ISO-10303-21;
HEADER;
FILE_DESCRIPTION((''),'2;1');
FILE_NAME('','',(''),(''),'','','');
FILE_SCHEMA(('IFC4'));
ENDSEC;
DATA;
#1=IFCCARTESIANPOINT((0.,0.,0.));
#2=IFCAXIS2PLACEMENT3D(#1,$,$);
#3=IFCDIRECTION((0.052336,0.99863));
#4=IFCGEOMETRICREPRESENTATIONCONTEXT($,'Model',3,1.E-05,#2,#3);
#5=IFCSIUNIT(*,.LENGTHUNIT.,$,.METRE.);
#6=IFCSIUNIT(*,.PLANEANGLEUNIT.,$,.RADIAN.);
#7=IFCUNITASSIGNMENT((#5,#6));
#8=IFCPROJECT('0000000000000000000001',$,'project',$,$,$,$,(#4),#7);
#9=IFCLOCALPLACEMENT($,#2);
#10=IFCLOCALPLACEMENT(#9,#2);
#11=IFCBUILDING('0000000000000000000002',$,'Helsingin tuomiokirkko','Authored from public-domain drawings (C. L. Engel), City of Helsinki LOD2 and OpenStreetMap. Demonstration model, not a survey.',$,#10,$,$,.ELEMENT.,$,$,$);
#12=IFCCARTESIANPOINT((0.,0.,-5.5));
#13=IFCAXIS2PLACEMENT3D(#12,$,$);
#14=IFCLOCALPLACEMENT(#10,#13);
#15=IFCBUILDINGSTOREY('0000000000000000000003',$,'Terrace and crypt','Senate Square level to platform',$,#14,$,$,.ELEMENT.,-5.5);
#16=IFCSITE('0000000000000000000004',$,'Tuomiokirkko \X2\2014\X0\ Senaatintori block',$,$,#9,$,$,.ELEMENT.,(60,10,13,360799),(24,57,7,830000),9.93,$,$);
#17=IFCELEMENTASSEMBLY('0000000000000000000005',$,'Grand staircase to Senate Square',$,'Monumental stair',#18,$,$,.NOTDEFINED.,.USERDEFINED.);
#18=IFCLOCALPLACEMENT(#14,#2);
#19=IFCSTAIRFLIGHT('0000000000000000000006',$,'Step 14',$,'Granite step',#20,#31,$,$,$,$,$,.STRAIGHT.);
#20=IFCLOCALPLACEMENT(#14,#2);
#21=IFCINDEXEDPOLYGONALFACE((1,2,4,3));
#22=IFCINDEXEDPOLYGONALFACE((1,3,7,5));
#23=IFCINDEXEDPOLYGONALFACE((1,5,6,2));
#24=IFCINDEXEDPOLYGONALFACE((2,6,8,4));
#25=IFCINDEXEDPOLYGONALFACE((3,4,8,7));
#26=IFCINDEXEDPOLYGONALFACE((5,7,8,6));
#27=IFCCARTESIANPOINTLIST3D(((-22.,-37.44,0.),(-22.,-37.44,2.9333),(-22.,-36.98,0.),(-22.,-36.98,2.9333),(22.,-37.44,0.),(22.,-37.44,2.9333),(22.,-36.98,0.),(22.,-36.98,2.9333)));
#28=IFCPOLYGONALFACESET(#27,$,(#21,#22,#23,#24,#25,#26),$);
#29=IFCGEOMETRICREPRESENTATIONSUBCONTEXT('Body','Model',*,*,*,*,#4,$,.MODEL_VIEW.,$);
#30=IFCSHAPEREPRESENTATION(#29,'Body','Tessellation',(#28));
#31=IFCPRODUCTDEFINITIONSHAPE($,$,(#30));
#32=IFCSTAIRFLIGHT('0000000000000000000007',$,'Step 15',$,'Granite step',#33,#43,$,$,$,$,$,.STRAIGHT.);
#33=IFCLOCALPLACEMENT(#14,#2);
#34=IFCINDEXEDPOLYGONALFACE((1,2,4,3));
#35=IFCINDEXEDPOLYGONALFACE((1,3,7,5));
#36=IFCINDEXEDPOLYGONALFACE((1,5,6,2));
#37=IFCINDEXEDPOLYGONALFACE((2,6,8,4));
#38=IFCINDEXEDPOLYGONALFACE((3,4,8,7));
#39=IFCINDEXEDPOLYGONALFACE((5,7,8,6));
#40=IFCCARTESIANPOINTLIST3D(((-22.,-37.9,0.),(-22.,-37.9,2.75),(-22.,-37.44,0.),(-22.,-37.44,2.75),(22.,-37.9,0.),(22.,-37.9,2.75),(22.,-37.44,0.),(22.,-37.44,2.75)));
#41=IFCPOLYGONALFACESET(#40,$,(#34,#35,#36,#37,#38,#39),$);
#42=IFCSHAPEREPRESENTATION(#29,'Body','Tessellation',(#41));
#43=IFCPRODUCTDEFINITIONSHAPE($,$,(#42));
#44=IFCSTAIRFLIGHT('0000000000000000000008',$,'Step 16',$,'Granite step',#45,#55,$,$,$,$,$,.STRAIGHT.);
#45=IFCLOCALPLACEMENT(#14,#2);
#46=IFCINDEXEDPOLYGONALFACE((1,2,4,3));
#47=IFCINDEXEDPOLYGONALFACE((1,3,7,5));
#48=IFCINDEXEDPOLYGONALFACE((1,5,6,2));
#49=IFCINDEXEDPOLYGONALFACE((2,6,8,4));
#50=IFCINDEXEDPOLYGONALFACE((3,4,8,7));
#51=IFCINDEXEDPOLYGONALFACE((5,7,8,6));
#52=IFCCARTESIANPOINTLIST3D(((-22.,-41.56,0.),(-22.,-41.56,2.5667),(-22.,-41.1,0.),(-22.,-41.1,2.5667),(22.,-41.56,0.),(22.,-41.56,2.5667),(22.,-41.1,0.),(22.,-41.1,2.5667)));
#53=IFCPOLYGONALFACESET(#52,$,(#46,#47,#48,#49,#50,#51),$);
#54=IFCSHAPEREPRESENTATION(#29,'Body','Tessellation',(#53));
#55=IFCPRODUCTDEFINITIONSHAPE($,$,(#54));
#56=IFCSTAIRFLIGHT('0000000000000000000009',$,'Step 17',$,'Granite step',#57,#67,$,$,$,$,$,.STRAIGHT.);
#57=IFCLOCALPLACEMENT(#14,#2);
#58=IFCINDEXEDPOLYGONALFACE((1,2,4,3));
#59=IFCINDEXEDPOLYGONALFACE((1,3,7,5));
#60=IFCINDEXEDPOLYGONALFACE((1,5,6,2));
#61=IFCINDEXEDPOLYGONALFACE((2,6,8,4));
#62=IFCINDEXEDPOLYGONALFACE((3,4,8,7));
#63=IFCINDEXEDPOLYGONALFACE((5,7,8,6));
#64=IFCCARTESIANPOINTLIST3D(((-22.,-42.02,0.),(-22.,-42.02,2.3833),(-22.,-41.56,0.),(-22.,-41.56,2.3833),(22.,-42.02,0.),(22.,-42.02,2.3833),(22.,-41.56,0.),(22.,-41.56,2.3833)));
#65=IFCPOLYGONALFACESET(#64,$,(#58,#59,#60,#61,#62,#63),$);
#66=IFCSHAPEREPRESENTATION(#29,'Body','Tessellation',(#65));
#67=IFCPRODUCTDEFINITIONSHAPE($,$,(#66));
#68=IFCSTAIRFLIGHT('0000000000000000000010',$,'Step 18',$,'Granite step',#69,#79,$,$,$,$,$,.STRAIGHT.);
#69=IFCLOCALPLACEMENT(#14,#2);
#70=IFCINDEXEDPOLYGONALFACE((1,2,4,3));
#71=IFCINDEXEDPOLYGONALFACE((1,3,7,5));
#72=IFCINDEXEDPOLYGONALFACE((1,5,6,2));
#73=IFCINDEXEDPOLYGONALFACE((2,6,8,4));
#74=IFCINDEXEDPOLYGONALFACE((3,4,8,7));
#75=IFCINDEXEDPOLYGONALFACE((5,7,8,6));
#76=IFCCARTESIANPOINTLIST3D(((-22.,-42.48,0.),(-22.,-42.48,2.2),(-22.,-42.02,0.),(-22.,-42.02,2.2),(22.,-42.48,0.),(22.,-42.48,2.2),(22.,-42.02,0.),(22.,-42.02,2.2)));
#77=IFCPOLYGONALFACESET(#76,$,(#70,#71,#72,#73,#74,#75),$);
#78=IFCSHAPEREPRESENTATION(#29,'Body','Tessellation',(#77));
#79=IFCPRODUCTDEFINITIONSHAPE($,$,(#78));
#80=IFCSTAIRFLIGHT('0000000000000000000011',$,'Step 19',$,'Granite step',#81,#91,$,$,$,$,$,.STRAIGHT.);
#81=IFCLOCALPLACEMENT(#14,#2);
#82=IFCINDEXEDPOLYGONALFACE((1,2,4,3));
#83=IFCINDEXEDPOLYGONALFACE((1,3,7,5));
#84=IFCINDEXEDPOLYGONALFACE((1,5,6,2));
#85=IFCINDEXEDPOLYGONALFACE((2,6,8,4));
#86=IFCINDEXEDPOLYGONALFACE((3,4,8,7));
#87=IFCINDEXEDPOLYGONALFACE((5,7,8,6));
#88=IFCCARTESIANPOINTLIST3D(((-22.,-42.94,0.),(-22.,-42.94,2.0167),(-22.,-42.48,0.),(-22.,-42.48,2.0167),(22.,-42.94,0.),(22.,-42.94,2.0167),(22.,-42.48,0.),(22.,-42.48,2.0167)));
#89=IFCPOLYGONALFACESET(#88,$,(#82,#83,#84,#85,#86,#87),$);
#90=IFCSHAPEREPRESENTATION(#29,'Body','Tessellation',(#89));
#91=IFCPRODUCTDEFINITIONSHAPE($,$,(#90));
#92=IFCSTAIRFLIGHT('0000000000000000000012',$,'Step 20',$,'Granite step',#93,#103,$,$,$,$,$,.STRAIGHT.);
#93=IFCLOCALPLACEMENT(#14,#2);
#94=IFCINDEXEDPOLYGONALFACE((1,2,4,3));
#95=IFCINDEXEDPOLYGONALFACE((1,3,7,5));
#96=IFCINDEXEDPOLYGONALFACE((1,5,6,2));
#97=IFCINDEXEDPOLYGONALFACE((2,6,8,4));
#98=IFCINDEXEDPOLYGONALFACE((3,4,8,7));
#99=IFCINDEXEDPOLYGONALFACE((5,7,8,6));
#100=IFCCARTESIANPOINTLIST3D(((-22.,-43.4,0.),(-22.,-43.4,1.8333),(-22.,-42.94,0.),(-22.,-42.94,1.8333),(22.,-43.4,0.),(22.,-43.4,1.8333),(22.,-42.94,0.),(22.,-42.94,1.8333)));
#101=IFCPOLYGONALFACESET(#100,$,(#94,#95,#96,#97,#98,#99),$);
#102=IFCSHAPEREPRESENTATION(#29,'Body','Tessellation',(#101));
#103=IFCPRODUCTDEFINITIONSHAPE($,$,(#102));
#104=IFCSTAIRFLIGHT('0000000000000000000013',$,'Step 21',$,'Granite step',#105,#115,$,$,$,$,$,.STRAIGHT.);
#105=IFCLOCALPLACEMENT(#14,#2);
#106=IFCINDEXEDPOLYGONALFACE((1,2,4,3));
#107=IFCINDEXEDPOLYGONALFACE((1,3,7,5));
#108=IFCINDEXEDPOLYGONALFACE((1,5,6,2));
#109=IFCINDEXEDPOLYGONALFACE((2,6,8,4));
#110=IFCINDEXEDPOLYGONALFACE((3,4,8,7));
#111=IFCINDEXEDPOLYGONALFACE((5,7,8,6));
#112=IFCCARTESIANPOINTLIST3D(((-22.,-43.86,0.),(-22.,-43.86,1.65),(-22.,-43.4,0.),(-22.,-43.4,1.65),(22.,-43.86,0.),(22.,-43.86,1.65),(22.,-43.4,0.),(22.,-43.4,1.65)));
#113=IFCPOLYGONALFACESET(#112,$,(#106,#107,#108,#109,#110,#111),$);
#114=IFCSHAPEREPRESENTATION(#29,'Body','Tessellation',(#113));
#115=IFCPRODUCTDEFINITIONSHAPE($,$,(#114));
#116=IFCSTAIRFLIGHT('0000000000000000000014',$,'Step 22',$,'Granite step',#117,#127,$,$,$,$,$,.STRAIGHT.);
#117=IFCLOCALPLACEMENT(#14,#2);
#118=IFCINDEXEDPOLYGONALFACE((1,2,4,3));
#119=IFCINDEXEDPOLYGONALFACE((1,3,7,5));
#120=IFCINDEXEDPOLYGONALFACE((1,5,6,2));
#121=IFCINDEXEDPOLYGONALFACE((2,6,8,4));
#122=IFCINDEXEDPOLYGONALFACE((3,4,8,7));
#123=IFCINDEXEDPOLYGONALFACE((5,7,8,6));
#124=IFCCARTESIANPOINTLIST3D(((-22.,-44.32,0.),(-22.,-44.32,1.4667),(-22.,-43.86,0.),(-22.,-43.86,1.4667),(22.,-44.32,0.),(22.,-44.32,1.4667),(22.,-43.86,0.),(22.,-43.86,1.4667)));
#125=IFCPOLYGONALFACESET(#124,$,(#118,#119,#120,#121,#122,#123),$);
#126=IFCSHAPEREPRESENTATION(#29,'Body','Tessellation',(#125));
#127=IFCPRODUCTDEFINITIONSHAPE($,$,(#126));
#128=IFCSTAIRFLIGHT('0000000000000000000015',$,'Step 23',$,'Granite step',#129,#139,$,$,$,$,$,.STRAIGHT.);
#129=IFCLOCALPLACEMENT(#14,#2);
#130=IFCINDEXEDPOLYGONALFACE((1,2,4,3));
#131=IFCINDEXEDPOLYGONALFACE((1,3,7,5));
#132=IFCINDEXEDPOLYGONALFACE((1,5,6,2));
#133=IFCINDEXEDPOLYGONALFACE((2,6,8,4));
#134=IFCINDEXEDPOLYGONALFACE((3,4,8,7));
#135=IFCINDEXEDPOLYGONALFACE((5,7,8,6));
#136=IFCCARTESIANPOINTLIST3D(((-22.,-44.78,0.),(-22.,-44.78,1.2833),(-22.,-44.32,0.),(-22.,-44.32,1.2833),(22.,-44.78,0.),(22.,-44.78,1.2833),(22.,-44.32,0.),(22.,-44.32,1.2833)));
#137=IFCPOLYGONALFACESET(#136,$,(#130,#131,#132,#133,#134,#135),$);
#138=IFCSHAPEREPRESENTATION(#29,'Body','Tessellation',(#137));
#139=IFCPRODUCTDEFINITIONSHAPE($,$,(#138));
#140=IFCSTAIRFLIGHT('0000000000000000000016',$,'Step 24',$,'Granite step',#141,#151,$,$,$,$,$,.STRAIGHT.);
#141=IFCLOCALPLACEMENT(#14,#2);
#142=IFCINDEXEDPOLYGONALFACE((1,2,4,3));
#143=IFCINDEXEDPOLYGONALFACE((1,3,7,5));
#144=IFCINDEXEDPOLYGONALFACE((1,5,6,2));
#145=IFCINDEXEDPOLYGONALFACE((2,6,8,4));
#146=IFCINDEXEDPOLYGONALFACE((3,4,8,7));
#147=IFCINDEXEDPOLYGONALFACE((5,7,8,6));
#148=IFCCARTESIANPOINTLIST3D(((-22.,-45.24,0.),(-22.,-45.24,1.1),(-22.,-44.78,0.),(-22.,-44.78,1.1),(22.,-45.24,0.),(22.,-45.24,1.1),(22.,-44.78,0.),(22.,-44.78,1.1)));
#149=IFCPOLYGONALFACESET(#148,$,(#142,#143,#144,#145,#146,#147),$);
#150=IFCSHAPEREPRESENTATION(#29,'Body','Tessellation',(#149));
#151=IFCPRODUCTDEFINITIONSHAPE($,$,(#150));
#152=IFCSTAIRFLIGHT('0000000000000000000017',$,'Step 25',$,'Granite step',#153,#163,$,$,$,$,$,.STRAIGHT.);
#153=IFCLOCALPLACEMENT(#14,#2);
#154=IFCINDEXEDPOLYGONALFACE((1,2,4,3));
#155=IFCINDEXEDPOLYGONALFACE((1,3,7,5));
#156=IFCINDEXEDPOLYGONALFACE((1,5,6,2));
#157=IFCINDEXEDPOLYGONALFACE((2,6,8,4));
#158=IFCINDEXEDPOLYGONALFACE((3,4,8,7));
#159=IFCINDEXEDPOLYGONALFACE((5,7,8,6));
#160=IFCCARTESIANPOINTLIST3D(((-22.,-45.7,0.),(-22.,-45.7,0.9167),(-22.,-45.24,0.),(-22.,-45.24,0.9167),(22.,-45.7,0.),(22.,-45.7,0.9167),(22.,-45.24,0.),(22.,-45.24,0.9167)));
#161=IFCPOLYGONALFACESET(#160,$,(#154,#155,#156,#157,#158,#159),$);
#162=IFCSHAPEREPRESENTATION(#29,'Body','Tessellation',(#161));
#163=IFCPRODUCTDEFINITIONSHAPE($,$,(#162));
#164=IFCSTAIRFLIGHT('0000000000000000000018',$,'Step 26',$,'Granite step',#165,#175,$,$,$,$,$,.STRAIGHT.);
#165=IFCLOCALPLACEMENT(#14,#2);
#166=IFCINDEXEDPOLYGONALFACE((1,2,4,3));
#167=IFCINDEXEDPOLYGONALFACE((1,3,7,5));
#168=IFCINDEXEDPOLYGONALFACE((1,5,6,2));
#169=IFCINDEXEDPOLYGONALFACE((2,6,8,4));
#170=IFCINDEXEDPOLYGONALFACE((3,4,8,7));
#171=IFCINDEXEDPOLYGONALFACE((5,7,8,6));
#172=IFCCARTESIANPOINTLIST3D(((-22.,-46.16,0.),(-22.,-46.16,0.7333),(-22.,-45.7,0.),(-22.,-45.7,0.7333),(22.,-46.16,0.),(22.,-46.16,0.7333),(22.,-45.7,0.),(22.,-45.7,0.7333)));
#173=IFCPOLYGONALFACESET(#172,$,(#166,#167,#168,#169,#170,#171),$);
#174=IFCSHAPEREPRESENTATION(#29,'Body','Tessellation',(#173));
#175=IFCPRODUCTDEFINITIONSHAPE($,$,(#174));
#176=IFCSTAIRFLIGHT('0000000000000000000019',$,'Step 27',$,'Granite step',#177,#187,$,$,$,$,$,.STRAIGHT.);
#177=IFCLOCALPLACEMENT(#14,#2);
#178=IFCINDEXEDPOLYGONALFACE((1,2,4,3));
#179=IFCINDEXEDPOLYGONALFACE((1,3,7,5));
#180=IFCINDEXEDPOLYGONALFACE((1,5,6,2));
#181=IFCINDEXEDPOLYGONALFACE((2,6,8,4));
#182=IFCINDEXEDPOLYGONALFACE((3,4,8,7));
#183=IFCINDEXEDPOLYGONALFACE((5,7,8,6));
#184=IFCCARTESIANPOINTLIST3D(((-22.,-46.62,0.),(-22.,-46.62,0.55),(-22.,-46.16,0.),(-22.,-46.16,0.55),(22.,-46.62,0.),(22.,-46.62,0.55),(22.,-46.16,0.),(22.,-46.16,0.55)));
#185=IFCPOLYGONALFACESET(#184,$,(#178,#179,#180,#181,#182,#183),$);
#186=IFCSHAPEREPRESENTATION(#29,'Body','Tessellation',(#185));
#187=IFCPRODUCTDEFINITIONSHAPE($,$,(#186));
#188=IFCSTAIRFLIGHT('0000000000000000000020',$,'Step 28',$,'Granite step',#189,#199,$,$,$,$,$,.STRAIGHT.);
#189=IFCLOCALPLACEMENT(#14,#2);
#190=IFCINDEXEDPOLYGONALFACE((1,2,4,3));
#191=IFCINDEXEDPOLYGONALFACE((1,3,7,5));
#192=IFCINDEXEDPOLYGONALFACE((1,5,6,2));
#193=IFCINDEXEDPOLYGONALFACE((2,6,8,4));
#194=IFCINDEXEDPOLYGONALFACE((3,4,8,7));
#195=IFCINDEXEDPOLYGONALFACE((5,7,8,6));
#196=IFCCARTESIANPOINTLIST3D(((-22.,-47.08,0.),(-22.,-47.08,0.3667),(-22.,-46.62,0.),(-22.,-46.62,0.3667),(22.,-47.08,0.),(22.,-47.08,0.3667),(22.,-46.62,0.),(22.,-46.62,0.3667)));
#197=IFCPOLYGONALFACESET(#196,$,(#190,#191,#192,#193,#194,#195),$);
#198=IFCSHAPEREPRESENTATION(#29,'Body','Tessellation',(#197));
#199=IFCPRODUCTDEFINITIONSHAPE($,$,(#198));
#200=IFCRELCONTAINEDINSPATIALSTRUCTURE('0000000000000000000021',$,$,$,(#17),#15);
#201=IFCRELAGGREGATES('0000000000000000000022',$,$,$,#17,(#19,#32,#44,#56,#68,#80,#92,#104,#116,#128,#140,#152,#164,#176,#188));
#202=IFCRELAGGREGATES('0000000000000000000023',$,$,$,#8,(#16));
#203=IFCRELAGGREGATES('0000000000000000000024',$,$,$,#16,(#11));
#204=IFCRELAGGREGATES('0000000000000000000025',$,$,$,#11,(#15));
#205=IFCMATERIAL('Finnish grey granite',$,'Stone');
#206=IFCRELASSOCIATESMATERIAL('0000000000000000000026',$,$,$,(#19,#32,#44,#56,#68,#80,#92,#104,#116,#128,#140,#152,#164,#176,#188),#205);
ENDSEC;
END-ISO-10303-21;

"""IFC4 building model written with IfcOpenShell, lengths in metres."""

from ifc_helpers import new_model, si_unit, direction, frame, origin, origin_2d_with_axis, place, context, subcontext, project, spatial, rectangle, extrude, material, element, aggregate, save


model = new_model("IFC4")

# Units and contexts
model_context = context("Model", 3, precision=1e-05, world=origin(), true_north=direction((0.052336, 0.99863)))
body_context = subcontext(model_context, "Body", "Model", "MODEL_VIEW")
ifc_project = project(units=[si_unit("LENGTHUNIT", "METRE"), si_unit("PLANEANGLEUNIT", "RADIAN")], contexts=[model_context])

# Site, building, storey
site_placement = place(None, origin())
site = spatial("IfcSite", under=ifc_project, at=site_placement, Name="Tuomiokirkko — Senaatintori block", CompositionType="ELEMENT", RefLatitude=(60, 10, 13, 360799), RefLongitude=(24, 57, 7, 830000), RefElevation=9.93)
building_placement = place(site_placement, origin())
building = spatial("IfcBuilding", under=site, at=building_placement, Name="Helsingin tuomiokirkko", Description="Authored from public-domain drawings (C. L. Engel), City of Helsinki LOD2 and OpenStreetMap. Demonstration model, not a survey.", CompositionType="ELEMENT")
storey_placement = place(building_placement, frame((0.0, 0.0, -5.5)))
storey = spatial("IfcBuildingStorey", under=building, at=storey_placement, Name="Terrace and crypt", Description="Senate Square level to platform", CompositionType="ELEMENT", Elevation=-5.5)

# Element assembly, stair flights
assembly_placement = place(building_placement, origin())
assembly = element("IfcElementAssembly", 1, at=assembly_placement, inside=storey, Name="Grand staircase to Senate Square", ObjectType="Monumental stair", AssemblyPlace="NOTDEFINED", PredefinedType="USERDEFINED")
ifc_material_1 = material(Name="Finnish grey granite", Category="Stone")
stair_flight_1_placement = place(building_placement, origin())
stair_flight_1 = element("IfcStairFlight", 2, at=stair_flight_1_placement, material=ifc_material_1, Name="Step 14", ObjectType="Granite step", PredefinedType="STRAIGHT", context=body_context, shape_type="SweptSolid", body=[
    extrude(rectangle(XDim=44.0, YDim=0.46, at=origin_2d_with_axis()), frame((0.0, -37.21, -5.5)), (0.0, 0.0, 1.0), 2.9333),
])
stair_flight_2_placement = place(building_placement, origin())
stair_flight_2 = element("IfcStairFlight", 3, at=stair_flight_2_placement, material=ifc_material_1, Name="Step 15", ObjectType="Granite step", PredefinedType="STRAIGHT", context=body_context, shape_type="SweptSolid", body=[
    extrude(rectangle(XDim=44.0, YDim=0.46, at=origin_2d_with_axis()), frame((0.0, -37.67, -5.5)), (0.0, 0.0, 1.0), 2.75),
])
stair_flight_3_placement = place(building_placement, origin())
stair_flight_3 = element("IfcStairFlight", 4, at=stair_flight_3_placement, material=ifc_material_1, Name="Step 16", ObjectType="Granite step", PredefinedType="STRAIGHT", context=body_context, shape_type="SweptSolid", body=[
    extrude(rectangle(XDim=44.0, YDim=0.46, at=origin_2d_with_axis()), frame((0.0, -41.33, -5.5)), (0.0, 0.0, 1.0), 2.5667),
])
stair_flight_4_placement = place(building_placement, origin())
stair_flight_4 = element("IfcStairFlight", 5, at=stair_flight_4_placement, material=ifc_material_1, Name="Step 17", ObjectType="Granite step", PredefinedType="STRAIGHT", context=body_context, shape_type="SweptSolid", body=[
    extrude(rectangle(XDim=44.0, YDim=0.46, at=origin_2d_with_axis()), frame((0.0, -41.79, -5.5)), (0.0, 0.0, 1.0), 2.3833),
])
stair_flight_5_placement = place(building_placement, origin())
stair_flight_5 = element("IfcStairFlight", 6, at=stair_flight_5_placement, material=ifc_material_1, Name="Step 18", ObjectType="Granite step", PredefinedType="STRAIGHT", context=body_context, shape_type="SweptSolid", body=[
    extrude(rectangle(XDim=44.0, YDim=0.46, at=origin_2d_with_axis()), frame((0.0, -42.25, -5.5)), (0.0, 0.0, 1.0), 2.2),
])
stair_flight_6_placement = place(building_placement, origin())
stair_flight_6 = element("IfcStairFlight", 7, at=stair_flight_6_placement, material=ifc_material_1, Name="Step 19", ObjectType="Granite step", PredefinedType="STRAIGHT", context=body_context, shape_type="SweptSolid", body=[
    extrude(rectangle(XDim=44.0, YDim=0.46, at=origin_2d_with_axis()), frame((0.0, -42.71, -5.5)), (0.0, 0.0, 1.0), 2.0167),
])
stair_flight_7_placement = place(building_placement, origin())
stair_flight_7 = element("IfcStairFlight", 8, at=stair_flight_7_placement, material=ifc_material_1, Name="Step 20", ObjectType="Granite step", PredefinedType="STRAIGHT", context=body_context, shape_type="SweptSolid", body=[
    extrude(rectangle(XDim=44.0, YDim=0.46, at=origin_2d_with_axis()), frame((0.0, -43.17, -5.5)), (0.0, 0.0, 1.0), 1.8333),
])
stair_flight_8_placement = place(building_placement, origin())
stair_flight_8 = element("IfcStairFlight", 9, at=stair_flight_8_placement, material=ifc_material_1, Name="Step 21", ObjectType="Granite step", PredefinedType="STRAIGHT", context=body_context, shape_type="SweptSolid", body=[
    extrude(rectangle(XDim=44.0, YDim=0.46, at=origin_2d_with_axis()), frame((0.0, -43.63, -5.5)), (0.0, 0.0, 1.0), 1.65),
])
stair_flight_9_placement = place(building_placement, origin())
stair_flight_9 = element("IfcStairFlight", 10, at=stair_flight_9_placement, material=ifc_material_1, Name="Step 22", ObjectType="Granite step", PredefinedType="STRAIGHT", context=body_context, shape_type="SweptSolid", body=[
    extrude(rectangle(XDim=44.0, YDim=0.46, at=origin_2d_with_axis()), frame((0.0, -44.09, -5.5)), (0.0, 0.0, 1.0), 1.4667),
])
stair_flight_10_placement = place(building_placement, origin())
stair_flight_10 = element("IfcStairFlight", 11, at=stair_flight_10_placement, material=ifc_material_1, Name="Step 23", ObjectType="Granite step", PredefinedType="STRAIGHT", context=body_context, shape_type="SweptSolid", body=[
    extrude(rectangle(XDim=44.0, YDim=0.46, at=origin_2d_with_axis()), frame((0.0, -44.55, -5.5)), (0.0, 0.0, 1.0), 1.2833),
])
stair_flight_11_placement = place(building_placement, origin())
stair_flight_11 = element("IfcStairFlight", 12, at=stair_flight_11_placement, material=ifc_material_1, Name="Step 24", ObjectType="Granite step", PredefinedType="STRAIGHT", context=body_context, shape_type="SweptSolid", body=[
    extrude(rectangle(XDim=44.0, YDim=0.46, at=origin_2d_with_axis()), frame((0.0, -45.01, -5.5)), (0.0, 0.0, 1.0), 1.1),
])
stair_flight_12_placement = place(building_placement, origin())
stair_flight_12 = element("IfcStairFlight", 13, at=stair_flight_12_placement, material=ifc_material_1, Name="Step 25", ObjectType="Granite step", PredefinedType="STRAIGHT", context=body_context, shape_type="SweptSolid", body=[
    extrude(rectangle(XDim=44.0, YDim=0.46, at=origin_2d_with_axis()), frame((0.0, -45.47, -5.5)), (0.0, 0.0, 1.0), 0.9167),
])
stair_flight_13_placement = place(building_placement, origin())
stair_flight_13 = element("IfcStairFlight", 14, at=stair_flight_13_placement, material=ifc_material_1, Name="Step 26", ObjectType="Granite step", PredefinedType="STRAIGHT", context=body_context, shape_type="SweptSolid", body=[
    extrude(rectangle(XDim=44.0, YDim=0.46, at=origin_2d_with_axis()), frame((0.0, -45.93, -5.5)), (0.0, 0.0, 1.0), 0.7333),
])
stair_flight_14_placement = place(building_placement, origin())
stair_flight_14 = element("IfcStairFlight", 15, at=stair_flight_14_placement, material=ifc_material_1, Name="Step 27", ObjectType="Granite step", PredefinedType="STRAIGHT", context=body_context, shape_type="SweptSolid", body=[
    extrude(rectangle(XDim=44.0, YDim=0.46, at=origin_2d_with_axis()), frame((0.0, -46.39, -5.5)), (0.0, 0.0, 1.0), 0.55),
])
stair_flight_15_placement = place(building_placement, origin())
stair_flight_15 = element("IfcStairFlight", 16, at=stair_flight_15_placement, material=ifc_material_1, Name="Step 28", ObjectType="Granite step", PredefinedType="STRAIGHT", context=body_context, shape_type="SweptSolid", body=[
    extrude(rectangle(XDim=44.0, YDim=0.46, at=origin_2d_with_axis()), frame((0.0, -46.85, -5.5)), (0.0, 0.0, 1.0), 0.3667),
])
aggregate(assembly, [stair_flight_1, stair_flight_2, stair_flight_3, stair_flight_4, stair_flight_5, stair_flight_6, stair_flight_7, stair_flight_8, stair_flight_9, stair_flight_10, stair_flight_11, stair_flight_12, stair_flight_13, stair_flight_14, stair_flight_15])

save(model, "model.ifc")
